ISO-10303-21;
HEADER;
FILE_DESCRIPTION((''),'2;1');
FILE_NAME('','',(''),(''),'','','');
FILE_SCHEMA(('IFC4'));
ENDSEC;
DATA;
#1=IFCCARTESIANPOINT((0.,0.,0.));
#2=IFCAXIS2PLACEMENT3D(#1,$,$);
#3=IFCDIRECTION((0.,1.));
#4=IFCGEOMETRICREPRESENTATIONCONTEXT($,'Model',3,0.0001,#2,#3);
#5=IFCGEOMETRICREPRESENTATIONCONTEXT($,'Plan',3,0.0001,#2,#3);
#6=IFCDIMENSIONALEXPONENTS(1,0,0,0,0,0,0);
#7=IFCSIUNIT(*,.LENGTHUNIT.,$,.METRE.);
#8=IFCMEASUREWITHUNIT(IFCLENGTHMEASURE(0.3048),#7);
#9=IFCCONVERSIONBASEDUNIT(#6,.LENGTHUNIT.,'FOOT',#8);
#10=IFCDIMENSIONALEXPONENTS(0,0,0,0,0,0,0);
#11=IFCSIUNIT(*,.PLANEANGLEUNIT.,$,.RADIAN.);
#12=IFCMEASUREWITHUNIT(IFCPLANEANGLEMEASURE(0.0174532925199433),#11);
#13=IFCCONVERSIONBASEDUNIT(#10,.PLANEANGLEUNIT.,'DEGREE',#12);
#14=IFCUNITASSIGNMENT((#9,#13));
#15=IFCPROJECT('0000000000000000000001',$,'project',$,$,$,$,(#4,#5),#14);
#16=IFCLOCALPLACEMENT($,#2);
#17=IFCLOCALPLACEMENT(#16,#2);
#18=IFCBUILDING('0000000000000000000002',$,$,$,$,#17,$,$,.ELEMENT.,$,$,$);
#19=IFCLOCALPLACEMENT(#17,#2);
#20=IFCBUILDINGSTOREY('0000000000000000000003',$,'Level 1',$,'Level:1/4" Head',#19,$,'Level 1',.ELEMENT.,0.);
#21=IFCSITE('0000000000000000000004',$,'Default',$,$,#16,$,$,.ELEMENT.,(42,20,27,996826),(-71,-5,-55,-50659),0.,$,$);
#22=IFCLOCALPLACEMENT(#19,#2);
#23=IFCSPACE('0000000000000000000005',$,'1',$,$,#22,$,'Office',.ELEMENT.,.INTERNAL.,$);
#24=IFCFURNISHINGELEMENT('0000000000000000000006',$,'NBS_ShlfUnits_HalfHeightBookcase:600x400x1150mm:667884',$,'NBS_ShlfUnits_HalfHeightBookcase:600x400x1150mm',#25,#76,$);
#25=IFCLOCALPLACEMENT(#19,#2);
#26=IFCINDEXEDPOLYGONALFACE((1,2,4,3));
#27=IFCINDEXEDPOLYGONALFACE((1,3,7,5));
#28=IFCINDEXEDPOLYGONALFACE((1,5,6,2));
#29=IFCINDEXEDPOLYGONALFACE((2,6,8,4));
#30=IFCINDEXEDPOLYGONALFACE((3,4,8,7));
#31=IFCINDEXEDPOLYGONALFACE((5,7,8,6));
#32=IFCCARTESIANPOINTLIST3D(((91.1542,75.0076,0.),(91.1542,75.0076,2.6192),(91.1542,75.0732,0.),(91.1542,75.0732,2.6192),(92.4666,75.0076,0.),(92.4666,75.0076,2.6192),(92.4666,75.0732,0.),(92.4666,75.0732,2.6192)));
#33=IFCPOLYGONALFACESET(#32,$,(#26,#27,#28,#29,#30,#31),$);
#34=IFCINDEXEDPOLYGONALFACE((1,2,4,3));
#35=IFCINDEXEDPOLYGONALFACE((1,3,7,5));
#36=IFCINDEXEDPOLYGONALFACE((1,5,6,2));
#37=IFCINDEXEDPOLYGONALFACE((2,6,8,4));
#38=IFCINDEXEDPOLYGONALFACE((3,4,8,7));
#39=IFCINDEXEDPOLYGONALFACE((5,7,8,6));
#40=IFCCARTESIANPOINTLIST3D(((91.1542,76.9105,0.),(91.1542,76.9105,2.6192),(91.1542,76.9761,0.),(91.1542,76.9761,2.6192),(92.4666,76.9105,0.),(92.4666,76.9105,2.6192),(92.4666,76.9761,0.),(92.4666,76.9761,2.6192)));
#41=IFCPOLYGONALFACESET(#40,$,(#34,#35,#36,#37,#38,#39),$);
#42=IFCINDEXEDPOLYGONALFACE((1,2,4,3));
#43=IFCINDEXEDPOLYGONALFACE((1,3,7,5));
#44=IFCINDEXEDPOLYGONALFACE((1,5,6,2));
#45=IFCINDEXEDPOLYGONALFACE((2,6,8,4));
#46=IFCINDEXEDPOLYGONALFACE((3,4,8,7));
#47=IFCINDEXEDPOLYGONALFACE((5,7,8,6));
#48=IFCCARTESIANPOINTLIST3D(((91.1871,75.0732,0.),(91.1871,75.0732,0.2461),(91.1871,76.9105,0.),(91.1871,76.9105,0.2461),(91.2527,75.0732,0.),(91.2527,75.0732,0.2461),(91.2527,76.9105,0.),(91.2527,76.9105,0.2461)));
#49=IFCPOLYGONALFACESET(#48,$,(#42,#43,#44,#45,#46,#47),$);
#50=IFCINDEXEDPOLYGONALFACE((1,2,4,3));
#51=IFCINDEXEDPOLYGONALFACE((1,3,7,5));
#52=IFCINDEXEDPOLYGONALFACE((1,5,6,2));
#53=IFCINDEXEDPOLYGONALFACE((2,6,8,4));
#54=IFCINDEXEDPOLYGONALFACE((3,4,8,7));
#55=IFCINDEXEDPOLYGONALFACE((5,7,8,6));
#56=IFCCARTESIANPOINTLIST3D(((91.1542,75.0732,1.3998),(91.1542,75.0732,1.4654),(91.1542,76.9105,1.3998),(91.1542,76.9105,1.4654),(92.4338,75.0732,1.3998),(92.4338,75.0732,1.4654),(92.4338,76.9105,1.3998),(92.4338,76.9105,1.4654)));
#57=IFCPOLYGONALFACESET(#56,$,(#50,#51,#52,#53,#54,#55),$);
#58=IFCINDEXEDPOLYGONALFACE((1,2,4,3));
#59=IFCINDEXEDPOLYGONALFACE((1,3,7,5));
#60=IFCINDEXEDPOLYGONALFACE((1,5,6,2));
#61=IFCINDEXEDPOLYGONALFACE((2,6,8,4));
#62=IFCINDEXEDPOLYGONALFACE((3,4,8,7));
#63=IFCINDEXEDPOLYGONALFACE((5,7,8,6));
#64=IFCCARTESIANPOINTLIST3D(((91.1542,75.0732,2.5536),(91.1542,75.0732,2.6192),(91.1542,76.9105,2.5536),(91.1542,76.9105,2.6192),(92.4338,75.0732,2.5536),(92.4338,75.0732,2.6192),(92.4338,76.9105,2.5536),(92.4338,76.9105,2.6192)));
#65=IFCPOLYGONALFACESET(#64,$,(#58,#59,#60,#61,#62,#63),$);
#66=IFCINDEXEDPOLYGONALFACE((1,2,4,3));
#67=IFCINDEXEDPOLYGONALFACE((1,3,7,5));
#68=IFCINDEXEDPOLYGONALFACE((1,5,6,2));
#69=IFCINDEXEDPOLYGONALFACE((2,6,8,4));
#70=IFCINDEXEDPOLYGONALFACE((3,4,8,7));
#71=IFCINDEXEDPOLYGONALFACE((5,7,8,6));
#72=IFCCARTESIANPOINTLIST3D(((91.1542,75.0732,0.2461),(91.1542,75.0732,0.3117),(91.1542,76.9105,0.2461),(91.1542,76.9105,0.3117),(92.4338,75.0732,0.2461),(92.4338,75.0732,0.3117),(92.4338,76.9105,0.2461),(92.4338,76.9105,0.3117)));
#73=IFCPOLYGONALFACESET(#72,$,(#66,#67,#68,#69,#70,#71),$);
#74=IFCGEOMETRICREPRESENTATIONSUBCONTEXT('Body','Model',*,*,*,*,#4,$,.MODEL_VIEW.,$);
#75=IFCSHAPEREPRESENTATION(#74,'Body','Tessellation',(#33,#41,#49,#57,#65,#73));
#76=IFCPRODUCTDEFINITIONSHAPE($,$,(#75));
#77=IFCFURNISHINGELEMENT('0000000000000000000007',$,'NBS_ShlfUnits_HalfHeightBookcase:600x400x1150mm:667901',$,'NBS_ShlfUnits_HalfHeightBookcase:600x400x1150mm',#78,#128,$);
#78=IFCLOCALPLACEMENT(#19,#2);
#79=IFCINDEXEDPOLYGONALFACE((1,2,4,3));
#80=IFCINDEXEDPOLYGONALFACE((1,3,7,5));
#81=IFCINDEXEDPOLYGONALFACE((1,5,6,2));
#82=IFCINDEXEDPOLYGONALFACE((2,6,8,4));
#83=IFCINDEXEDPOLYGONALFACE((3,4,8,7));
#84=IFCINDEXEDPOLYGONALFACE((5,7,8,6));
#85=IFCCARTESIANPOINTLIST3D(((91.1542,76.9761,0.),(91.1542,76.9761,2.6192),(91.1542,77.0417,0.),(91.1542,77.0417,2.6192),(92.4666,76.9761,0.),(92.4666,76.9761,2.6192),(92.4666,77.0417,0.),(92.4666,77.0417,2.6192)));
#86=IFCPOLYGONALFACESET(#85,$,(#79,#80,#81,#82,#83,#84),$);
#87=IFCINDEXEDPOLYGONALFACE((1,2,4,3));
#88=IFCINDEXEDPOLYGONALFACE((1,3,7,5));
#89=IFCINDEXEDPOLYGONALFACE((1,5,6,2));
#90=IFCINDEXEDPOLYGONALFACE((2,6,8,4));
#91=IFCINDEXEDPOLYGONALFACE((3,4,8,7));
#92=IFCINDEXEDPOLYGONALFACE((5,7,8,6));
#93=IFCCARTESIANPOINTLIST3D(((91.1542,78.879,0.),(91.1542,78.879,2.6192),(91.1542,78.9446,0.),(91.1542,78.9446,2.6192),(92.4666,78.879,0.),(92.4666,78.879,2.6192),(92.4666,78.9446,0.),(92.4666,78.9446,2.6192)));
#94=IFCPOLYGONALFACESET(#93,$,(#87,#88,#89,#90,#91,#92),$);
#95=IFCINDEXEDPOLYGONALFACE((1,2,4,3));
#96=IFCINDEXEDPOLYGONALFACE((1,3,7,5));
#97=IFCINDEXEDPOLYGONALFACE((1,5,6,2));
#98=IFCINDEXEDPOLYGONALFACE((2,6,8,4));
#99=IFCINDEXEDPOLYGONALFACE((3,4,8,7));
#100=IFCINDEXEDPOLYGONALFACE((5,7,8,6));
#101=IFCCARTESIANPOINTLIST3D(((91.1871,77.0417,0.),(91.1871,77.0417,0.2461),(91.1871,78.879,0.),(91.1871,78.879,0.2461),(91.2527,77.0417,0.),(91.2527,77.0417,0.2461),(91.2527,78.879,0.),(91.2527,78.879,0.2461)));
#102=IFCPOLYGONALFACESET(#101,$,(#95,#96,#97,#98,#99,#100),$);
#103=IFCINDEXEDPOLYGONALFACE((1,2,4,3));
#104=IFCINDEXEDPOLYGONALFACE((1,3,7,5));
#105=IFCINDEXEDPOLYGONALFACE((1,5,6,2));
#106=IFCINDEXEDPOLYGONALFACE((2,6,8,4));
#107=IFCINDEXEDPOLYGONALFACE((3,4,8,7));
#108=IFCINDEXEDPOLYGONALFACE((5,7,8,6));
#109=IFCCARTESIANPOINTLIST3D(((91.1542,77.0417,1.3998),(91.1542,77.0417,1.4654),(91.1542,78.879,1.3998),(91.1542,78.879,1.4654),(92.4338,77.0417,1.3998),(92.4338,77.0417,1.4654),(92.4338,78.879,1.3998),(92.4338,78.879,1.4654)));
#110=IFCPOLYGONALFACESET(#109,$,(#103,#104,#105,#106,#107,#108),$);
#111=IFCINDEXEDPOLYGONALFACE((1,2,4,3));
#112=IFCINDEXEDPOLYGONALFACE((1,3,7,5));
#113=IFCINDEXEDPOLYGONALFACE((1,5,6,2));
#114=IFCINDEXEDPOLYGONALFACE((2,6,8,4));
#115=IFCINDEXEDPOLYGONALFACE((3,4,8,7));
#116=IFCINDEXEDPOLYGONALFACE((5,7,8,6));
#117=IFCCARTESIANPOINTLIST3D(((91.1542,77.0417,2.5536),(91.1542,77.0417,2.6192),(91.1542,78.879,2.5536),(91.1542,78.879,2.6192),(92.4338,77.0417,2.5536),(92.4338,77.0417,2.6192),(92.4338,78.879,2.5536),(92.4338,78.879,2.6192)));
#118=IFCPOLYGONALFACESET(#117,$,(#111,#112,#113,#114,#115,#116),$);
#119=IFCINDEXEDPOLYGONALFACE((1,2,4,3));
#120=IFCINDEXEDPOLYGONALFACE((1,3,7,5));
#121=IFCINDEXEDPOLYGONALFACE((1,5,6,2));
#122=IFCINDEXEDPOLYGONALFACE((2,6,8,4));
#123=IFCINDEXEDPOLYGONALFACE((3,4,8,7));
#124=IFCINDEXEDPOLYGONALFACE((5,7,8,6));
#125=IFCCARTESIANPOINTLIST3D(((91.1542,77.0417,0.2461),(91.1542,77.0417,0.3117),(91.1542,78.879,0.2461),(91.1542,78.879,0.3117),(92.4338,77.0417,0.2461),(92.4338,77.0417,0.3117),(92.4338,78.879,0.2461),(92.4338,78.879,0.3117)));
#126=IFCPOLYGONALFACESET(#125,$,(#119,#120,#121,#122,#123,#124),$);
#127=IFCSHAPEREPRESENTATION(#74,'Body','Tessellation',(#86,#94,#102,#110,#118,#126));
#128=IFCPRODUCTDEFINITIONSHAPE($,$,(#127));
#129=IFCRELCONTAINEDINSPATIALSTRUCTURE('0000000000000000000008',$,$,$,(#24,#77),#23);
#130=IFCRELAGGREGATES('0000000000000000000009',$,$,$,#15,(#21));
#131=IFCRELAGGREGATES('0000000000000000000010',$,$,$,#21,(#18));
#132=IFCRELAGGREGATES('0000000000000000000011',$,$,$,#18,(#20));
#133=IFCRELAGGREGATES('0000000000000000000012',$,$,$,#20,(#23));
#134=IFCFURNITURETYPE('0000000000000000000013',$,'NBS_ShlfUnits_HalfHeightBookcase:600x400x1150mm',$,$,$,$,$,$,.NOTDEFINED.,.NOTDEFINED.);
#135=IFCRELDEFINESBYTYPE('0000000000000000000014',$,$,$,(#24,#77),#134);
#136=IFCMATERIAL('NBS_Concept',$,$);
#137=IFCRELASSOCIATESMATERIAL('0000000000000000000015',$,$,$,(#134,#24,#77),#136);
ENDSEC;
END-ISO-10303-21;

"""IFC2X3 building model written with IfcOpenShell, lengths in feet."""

from ifc_helpers import new_model, entity, si_unit, converted_unit, direction, frame, frame_2d, origin, origin_2d_with_axis, place, context, subcontext, project, spatial, rectangle, extrude, source, transform, mapped, material, type_object, type_shapes, element, save


model = new_model("IFC2X3")

# Units and contexts
model_context = context("Model", 3, precision=0.0001, world=origin(), true_north=direction((0.0, 1.0)))
plan_context = context("Plan", 3, precision=0.0001, world=origin(), true_north=direction((0.0, 1.0)))
body_context = subcontext(model_context, "Body", "Model", "MODEL_VIEW")
ifc_project = project(units=[converted_unit("LENGTHUNIT", "FOOT", entity("IfcLengthMeasure", 0.3048), si_unit("LENGTHUNIT", "METRE"), dimensions=[1, 0, 0, 0, 0, 0, 0]), converted_unit("PLANEANGLEUNIT", "DEGREE", entity("IfcPlaneAngleMeasure", 0.0174532925199433), si_unit("PLANEANGLEUNIT", "RADIAN"), dimensions=[0, 0, 0, 0, 0, 0, 0])], contexts=[model_context, plan_context])

# Site, building, storey
site_placement = place(None, origin())
site = spatial("IfcSite", under=ifc_project, at=site_placement, Name="Default", CompositionType="ELEMENT", RefLatitude=(42, 20, 27, 996826), RefLongitude=(-71, -5, -55, -50659), RefElevation=0.0)
building_placement = place(site_placement, origin())
building = spatial("IfcBuilding", under=site, at=building_placement, CompositionType="ELEMENT")
storey_placement = place(building_placement, origin())
storey = spatial("IfcBuildingStorey", under=building, at=storey_placement, Name="Level 1", ObjectType="Level:1/4\" Head", LongName="Level 1", CompositionType="ELEMENT", Elevation=0.0)

# Shared definitions
space_placement = place(storey_placement, origin())
space = spatial("IfcSpace", under=storey, at=space_placement, Name="1", LongName="Office", CompositionType="ELEMENT", InteriorOrExteriorSpace="INTERNAL")

# Furnishing elements
ifc_material_1 = material(Name="NBS_Concept")
furniture_type_1 = type_object("IfcFurnitureType", Name="NBS_ShlfUnits_HalfHeightBookcase:600x400x1150mm", AssemblyPlace="NOTDEFINED", material=ifc_material_1)
shared_shape_1 = source(origin(), body_context, "Body", "SweptSolid", [
    extrude(rectangle(XDim=0.0656, YDim=1.3123, at=origin_2d_with_axis()), frame((0.9514, -0.6562, 0.0), z_axis=(0.0, 0.0, 1.0), x_axis=(-1.0, 0.0, 0.0)), (0.0, 0.0, 1.0), 2.6192),
    extrude(rectangle(XDim=0.0656, YDim=1.3123, at=origin_2d_with_axis()), frame((-0.9514, -0.6562, 0.0), z_axis=(0.0, 0.0, 1.0), x_axis=(-1.0, 0.0, 0.0)), (0.0, 0.0, 1.0), 2.6192),
    extrude(rectangle(XDim=1.8373, YDim=0.0656, at=origin_2d_with_axis()), frame((0.0, -1.2467, 0.0), z_axis=(0.0, 0.0, 1.0), x_axis=(-1.0, 0.0, 0.0)), (0.0, 0.0, 1.0), 0.2461),
    extrude(rectangle(XDim=1.2795, YDim=1.8373, at=frame_2d((0.0, 0.0), x_axis=(1.0, 0.0))), frame((0.0, -0.6726, 1.3998), z_axis=(0.0, 0.0, 1.0), x_axis=(0.0, 1.0, 0.0)), (0.0, 0.0, 1.0), 0.0656),
    extrude(rectangle(XDim=1.2795, YDim=1.8373, at=frame_2d((0.0, 0.0), x_axis=(1.0, 0.0))), frame((0.0, -0.6726, 2.5536), z_axis=(0.0, 0.0, 1.0), x_axis=(0.0, 1.0, 0.0)), (0.0, 0.0, 1.0), 0.0656),
    extrude(rectangle(XDim=1.2795, YDim=1.8373, at=frame_2d((0.0, 0.0), x_axis=(1.0, 0.0))), frame((0.0, -0.6726, 0.2461), z_axis=(0.0, 0.0, 1.0), x_axis=(0.0, 1.0, 0.0)), (0.0, 0.0, 1.0), 0.0656),
])
type_shapes(furniture_type_1, [shared_shape_1])
for number, where, z_axis, x_axis, name in (
    (1, (92.4666, 75.9919, 0.0), (0.0, 0.0, 1.0), (0.0, -1.0, 0.0), "NBS_ShlfUnits_HalfHeightBookcase:600x400x1150mm:667884"),
    (2, (92.4666, 77.9604, 0.0), (0.0, 0.0, 1.0), (0.0, -1.0, 0.0), "NBS_ShlfUnits_HalfHeightBookcase:600x400x1150mm:667901"),
):
    element("IfcFurnishingElement", number, at=place(space_placement, frame(where, z_axis=z_axis, x_axis=x_axis)), inside=space, type_object=furniture_type_1, material=ifc_material_1, Name=name, ObjectType="NBS_ShlfUnits_HalfHeightBookcase:600x400x1150mm", context=body_context, shape_type="MappedRepresentation", body=[
        mapped(shared_shape_1, transform((0.0, 0.0, 0.0), scale=1.0)),
    ])

save(model, "model.ifc")
